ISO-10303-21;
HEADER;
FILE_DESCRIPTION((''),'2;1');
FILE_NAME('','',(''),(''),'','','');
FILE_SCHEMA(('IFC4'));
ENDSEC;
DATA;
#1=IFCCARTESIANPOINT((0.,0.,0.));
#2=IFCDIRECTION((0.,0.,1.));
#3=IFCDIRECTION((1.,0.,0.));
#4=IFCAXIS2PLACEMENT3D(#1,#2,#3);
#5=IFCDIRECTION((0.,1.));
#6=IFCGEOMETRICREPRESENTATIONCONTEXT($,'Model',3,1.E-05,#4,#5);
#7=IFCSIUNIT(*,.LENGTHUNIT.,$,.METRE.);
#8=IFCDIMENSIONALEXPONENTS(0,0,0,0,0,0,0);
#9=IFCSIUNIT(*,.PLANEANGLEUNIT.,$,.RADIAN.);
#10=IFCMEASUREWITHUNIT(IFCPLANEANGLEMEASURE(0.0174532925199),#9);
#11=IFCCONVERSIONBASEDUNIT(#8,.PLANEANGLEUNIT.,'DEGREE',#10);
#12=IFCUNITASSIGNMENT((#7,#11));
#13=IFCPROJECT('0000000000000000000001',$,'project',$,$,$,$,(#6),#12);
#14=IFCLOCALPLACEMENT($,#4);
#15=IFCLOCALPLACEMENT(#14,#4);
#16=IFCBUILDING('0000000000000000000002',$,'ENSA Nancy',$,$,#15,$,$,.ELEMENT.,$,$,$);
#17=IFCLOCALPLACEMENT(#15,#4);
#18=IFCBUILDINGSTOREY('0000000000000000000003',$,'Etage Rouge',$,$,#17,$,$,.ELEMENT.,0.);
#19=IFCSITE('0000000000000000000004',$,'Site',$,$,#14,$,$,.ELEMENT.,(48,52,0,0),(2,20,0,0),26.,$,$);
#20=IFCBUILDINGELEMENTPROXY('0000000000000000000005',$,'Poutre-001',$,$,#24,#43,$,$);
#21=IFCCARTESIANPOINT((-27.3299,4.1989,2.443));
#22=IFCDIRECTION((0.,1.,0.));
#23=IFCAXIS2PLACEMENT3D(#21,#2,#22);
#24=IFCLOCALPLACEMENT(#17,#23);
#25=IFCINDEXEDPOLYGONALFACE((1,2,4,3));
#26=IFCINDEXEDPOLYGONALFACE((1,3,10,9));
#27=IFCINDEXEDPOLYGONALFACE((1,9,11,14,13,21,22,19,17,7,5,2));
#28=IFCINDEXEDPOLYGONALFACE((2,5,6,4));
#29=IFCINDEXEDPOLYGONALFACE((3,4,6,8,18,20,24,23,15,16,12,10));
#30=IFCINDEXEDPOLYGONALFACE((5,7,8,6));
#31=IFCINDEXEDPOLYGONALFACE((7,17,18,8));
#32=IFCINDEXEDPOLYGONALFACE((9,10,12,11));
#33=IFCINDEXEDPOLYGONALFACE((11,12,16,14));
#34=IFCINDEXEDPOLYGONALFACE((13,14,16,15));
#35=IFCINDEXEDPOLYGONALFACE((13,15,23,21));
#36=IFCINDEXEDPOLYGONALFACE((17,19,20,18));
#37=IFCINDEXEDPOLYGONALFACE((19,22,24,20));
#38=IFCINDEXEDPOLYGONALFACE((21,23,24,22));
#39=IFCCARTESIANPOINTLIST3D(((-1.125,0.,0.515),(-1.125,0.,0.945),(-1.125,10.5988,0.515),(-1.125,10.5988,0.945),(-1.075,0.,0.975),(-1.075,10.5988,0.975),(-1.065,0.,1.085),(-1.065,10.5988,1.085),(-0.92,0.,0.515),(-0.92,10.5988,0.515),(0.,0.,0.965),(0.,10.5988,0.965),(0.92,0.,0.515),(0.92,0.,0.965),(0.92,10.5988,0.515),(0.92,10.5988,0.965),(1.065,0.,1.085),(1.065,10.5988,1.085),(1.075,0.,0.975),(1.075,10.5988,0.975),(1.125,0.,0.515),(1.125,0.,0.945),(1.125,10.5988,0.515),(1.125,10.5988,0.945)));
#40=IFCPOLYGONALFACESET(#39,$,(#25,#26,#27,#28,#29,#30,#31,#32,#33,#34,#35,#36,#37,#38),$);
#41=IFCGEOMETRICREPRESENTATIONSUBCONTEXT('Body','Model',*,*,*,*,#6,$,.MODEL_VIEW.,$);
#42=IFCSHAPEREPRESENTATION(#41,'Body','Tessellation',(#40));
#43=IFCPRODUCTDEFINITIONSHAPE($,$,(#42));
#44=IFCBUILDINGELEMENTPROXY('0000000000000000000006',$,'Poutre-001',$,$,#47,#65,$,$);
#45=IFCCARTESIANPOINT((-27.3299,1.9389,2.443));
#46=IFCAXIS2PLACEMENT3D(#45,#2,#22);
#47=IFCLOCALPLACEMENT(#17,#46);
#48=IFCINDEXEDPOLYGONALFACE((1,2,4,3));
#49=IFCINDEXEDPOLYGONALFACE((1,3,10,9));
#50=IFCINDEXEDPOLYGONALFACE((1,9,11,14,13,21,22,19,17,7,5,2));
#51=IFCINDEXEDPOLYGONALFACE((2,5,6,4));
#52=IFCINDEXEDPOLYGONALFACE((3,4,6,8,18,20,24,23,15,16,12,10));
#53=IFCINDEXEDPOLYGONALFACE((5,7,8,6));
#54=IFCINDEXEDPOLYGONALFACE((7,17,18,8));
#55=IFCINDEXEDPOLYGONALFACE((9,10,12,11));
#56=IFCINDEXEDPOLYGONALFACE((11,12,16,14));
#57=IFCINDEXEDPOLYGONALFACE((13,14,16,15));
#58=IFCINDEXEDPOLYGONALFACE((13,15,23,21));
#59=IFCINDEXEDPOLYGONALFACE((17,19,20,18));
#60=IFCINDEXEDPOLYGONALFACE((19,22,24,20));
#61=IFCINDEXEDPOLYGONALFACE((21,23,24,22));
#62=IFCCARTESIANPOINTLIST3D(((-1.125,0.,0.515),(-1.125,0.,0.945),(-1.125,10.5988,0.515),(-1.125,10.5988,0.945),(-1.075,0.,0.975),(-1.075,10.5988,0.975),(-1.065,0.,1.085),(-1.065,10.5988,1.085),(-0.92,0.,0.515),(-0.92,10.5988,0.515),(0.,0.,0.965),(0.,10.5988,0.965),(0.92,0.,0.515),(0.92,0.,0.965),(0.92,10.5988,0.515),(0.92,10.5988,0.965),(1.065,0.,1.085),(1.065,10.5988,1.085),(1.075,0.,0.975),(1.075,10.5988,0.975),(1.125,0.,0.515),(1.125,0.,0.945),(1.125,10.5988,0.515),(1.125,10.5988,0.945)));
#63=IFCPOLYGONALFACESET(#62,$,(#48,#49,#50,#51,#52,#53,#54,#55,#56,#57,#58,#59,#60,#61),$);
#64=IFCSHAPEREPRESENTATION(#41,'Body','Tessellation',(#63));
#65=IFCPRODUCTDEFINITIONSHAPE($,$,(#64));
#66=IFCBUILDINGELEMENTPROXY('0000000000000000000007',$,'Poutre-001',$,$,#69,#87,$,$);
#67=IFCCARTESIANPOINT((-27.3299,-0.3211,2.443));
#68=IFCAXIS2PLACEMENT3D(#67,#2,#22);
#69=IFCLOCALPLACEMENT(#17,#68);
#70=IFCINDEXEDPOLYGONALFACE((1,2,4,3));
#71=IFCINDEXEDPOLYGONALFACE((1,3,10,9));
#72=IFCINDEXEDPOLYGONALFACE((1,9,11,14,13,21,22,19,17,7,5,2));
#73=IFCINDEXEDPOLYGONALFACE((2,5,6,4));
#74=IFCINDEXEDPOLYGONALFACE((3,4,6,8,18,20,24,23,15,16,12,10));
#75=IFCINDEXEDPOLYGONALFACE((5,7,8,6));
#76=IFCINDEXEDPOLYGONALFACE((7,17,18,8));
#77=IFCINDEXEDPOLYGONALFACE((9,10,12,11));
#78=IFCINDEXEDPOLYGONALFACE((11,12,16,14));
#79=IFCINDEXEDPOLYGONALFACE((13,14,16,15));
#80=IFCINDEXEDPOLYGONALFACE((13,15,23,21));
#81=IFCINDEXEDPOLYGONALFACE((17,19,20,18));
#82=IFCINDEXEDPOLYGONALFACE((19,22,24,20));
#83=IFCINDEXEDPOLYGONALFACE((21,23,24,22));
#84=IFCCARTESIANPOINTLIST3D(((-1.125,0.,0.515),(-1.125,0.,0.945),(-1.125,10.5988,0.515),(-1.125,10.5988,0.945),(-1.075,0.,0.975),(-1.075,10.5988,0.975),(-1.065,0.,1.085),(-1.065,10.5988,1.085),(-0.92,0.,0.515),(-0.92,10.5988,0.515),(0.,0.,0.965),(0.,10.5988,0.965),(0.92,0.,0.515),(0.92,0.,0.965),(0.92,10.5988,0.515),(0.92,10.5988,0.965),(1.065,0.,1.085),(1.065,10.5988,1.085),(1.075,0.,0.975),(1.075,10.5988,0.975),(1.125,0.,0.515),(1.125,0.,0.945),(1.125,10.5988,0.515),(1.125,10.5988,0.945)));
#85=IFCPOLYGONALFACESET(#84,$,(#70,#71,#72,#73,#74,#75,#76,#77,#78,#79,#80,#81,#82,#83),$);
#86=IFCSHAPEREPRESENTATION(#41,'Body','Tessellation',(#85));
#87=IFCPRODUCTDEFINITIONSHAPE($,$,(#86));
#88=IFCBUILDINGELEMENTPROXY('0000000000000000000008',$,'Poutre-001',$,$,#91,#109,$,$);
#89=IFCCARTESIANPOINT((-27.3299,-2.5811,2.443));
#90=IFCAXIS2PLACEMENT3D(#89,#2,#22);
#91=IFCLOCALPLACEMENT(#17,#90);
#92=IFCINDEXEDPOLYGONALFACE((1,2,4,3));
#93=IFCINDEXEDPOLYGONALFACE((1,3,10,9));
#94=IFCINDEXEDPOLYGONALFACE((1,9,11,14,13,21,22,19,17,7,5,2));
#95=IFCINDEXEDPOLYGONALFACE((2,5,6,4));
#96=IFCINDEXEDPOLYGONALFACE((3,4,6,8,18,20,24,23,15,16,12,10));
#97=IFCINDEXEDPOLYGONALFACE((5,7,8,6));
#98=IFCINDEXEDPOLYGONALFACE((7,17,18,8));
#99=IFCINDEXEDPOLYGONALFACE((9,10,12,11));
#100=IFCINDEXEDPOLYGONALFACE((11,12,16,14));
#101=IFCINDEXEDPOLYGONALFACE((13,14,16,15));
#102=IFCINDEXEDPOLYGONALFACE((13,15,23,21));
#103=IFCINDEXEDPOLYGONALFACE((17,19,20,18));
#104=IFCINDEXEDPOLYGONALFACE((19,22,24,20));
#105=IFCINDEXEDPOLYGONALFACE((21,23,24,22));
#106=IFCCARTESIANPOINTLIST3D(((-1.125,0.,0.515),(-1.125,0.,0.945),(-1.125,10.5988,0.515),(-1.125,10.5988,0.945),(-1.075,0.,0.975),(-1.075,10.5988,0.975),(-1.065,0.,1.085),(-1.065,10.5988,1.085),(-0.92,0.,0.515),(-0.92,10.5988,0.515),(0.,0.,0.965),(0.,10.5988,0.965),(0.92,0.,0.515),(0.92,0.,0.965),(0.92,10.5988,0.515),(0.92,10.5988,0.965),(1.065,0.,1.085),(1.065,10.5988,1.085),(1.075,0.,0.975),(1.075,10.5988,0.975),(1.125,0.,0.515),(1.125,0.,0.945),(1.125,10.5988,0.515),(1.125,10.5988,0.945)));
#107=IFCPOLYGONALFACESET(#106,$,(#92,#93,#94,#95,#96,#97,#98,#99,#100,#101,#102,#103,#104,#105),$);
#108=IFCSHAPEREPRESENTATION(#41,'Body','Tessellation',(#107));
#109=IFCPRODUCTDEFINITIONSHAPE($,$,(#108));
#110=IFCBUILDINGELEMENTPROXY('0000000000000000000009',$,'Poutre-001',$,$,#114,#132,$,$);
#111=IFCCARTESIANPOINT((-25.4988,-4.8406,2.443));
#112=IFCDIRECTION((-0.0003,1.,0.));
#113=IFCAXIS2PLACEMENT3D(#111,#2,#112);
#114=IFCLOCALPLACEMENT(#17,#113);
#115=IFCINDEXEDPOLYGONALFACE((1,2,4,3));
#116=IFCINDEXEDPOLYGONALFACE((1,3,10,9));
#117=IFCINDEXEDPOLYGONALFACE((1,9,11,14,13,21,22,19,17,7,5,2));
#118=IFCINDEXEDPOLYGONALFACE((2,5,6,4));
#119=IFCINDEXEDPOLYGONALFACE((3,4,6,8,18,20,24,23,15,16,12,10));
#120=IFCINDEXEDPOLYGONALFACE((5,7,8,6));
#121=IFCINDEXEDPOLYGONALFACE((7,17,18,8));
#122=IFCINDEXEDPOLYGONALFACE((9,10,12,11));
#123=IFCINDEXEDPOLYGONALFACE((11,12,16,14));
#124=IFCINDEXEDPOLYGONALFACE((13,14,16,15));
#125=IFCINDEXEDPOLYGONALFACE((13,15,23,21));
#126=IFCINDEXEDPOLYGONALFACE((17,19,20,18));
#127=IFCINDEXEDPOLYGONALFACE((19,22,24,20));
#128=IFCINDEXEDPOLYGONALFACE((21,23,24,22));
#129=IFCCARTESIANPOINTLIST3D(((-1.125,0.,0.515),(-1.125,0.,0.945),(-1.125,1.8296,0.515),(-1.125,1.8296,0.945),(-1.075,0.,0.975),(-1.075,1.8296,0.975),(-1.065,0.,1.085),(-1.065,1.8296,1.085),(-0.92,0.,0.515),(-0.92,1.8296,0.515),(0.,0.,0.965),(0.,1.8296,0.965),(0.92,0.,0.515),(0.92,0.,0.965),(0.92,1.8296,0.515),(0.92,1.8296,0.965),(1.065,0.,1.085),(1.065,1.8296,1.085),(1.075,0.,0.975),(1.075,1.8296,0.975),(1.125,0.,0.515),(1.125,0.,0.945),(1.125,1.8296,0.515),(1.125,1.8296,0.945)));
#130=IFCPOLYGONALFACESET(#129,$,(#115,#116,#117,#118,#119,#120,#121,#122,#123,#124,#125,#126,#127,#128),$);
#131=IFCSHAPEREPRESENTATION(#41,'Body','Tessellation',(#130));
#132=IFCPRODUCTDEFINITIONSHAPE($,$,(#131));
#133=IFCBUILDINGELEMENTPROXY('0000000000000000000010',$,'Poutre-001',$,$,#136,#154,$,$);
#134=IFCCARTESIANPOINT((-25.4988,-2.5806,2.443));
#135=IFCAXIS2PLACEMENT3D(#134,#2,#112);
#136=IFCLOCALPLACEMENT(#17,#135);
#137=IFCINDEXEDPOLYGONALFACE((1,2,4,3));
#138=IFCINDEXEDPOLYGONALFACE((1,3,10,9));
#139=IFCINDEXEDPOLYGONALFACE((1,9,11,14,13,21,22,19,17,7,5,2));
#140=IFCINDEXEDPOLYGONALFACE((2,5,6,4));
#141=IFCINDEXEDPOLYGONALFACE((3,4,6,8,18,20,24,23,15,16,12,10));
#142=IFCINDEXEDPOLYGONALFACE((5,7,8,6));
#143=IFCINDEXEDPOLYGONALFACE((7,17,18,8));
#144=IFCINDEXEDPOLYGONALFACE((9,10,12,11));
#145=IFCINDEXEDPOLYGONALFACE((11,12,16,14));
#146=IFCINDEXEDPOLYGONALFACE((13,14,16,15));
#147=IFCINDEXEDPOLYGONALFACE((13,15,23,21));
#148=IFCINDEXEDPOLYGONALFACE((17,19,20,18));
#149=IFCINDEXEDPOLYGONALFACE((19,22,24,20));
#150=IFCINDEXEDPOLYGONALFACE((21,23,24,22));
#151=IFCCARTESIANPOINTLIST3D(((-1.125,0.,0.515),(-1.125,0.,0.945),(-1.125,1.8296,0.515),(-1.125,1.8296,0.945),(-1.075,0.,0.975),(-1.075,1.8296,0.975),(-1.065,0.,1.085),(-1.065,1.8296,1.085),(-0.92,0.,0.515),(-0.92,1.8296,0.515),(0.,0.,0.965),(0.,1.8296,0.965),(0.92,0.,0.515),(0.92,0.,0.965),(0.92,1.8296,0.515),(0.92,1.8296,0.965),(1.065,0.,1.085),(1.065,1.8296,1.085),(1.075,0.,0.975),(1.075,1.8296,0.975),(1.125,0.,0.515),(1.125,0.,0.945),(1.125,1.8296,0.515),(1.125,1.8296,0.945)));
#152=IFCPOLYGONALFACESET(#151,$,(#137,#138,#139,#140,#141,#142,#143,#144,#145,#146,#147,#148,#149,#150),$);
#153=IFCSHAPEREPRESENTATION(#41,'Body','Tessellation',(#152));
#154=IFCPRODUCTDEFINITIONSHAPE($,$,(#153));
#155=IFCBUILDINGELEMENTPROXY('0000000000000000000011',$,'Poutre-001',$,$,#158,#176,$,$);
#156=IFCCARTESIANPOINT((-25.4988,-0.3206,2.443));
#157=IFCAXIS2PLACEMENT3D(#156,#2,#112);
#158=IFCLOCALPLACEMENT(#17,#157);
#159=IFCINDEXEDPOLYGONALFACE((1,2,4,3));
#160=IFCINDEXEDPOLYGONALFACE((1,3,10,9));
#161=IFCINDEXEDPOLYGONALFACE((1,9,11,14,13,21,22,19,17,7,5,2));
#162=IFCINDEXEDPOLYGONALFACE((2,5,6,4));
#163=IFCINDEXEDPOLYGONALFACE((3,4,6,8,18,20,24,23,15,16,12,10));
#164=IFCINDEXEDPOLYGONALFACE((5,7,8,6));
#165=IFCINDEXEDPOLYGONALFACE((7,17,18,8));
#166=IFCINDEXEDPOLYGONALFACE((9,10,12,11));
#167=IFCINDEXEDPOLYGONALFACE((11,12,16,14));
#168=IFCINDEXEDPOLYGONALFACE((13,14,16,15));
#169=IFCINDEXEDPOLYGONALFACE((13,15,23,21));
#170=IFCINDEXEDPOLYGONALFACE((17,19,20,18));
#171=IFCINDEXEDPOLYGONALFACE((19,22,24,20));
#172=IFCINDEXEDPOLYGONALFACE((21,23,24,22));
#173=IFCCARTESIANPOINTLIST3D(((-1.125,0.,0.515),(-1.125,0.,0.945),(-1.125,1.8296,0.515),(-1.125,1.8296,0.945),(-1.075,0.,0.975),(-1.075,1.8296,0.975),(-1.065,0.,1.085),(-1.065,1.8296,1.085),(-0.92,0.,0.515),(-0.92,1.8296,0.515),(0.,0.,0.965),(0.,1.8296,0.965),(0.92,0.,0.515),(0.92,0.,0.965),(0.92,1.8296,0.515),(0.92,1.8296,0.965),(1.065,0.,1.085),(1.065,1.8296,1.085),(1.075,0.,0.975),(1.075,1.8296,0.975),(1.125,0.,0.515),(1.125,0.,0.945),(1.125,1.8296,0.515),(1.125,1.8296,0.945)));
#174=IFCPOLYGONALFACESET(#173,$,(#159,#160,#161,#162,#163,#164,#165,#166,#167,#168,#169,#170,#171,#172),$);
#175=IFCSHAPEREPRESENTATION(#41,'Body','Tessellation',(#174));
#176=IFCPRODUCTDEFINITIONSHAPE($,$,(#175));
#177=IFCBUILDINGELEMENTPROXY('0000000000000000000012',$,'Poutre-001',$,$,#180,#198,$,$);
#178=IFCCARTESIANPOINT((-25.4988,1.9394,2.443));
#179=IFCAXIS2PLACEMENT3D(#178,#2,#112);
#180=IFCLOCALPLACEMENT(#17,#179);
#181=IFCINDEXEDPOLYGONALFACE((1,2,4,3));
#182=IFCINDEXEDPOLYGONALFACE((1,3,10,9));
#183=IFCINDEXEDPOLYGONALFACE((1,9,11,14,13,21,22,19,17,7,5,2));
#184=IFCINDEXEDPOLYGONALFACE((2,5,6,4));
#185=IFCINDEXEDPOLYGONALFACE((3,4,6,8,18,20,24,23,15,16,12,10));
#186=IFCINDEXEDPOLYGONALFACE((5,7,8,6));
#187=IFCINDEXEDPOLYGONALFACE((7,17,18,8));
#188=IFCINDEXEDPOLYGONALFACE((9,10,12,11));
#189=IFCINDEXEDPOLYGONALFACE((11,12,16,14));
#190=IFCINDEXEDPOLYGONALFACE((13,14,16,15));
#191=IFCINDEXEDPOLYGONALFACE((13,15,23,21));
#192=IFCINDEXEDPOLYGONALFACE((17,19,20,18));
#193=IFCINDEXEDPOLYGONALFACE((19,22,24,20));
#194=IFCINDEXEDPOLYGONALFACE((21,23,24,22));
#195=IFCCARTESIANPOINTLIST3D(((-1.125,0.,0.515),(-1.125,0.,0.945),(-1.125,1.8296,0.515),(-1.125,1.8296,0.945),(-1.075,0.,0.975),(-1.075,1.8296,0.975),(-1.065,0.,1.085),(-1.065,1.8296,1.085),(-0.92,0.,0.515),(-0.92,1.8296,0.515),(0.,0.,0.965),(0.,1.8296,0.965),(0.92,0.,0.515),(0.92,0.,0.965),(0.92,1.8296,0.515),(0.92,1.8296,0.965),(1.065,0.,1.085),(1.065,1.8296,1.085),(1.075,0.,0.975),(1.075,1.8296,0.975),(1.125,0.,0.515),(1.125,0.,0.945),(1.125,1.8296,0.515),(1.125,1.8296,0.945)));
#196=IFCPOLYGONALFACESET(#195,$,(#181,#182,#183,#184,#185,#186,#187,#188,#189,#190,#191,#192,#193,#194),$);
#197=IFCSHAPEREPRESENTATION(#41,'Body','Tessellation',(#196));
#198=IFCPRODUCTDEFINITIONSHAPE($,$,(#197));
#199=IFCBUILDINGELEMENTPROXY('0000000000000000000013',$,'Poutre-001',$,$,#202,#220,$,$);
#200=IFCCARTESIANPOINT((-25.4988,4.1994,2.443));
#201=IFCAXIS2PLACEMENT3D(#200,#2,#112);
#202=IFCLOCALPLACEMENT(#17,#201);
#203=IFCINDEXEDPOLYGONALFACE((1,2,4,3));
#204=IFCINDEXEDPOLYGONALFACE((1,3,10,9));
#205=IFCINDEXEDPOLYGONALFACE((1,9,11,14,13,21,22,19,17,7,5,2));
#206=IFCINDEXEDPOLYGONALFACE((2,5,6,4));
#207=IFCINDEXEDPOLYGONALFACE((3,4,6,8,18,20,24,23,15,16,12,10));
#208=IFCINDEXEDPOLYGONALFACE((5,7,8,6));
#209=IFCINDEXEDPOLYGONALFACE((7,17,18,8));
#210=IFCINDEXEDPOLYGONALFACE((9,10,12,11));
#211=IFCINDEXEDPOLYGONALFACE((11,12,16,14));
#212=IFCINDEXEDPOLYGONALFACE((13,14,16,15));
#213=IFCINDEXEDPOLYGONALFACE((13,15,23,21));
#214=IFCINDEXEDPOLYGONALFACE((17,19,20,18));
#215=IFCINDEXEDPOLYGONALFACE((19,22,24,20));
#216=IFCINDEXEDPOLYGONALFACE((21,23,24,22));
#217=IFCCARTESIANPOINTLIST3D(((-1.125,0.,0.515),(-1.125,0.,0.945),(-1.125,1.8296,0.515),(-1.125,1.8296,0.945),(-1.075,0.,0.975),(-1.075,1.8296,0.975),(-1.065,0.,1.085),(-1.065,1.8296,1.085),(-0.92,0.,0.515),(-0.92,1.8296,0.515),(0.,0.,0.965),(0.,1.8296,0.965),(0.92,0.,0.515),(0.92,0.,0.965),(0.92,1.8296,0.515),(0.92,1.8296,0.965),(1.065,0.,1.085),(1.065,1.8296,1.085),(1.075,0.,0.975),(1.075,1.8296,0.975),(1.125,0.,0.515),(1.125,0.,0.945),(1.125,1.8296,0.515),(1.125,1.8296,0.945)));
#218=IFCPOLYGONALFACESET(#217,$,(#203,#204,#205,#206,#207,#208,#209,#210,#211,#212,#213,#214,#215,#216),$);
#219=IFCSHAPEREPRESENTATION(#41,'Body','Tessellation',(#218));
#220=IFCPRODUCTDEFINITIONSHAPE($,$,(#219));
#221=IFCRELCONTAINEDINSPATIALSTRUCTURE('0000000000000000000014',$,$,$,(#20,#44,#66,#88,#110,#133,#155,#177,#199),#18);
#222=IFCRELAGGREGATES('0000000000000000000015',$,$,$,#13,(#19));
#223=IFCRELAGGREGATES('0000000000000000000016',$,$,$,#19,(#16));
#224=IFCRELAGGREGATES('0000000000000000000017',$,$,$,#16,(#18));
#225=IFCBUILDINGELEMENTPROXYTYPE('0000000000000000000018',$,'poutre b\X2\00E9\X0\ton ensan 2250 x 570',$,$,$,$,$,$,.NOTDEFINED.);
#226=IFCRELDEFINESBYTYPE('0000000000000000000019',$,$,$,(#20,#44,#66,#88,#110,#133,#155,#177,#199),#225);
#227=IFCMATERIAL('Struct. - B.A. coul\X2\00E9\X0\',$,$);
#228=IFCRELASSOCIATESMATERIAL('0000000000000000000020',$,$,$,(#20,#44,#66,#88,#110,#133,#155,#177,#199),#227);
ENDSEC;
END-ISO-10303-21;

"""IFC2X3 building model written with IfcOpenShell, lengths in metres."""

from ifc_helpers import new_model, entity, si_unit, converted_unit, direction, frame, origin_with_axes, place, context, subcontext, project, spatial, polyline, outline, extrude, material, type_object, element, save


model = new_model("IFC2X3")

# Units and contexts
model_context = context("Model", 3, precision=1e-05, world=origin_with_axes(), true_north=direction((0.0, 1.0)))
body_context = subcontext(model_context, "Body", "Model", "MODEL_VIEW")
ifc_project = project(units=[si_unit("LENGTHUNIT", "METRE"), converted_unit("PLANEANGLEUNIT", "DEGREE", entity("IfcPlaneAngleMeasure", 0.0174532925199), si_unit("PLANEANGLEUNIT", "RADIAN"), dimensions=[0, 0, 0, 0, 0, 0, 0])], contexts=[model_context])

# Site, building, storey
site_placement = place(None, origin_with_axes())
site = spatial("IfcSite", under=ifc_project, at=site_placement, Name="Site", CompositionType="ELEMENT", RefLatitude=(48, 52, 0, 0), RefLongitude=(2, 20, 0, 0), RefElevation=26.0)
building_placement = place(site_placement, origin_with_axes())
building = spatial("IfcBuilding", under=site, at=building_placement, Name="ENSA Nancy", CompositionType="ELEMENT")
storey_placement = place(building_placement, origin_with_axes())
storey = spatial("IfcBuildingStorey", under=building, at=storey_placement, Name="Etage Rouge", CompositionType="ELEMENT", Elevation=0.0)

# Building element proxies
ifc_material_1 = material(Name="Struct. - B.A. coulé")
building_element_proxy_type_1 = type_object("IfcBuildingElementProxyType", Name="poutre béton ensan 2250 x 570", PredefinedType="NOTDEFINED")
proxy_1_placement = place(storey_placement, frame((-27.3299, 4.1989, 2.443), z_axis=(0.0, 0.0, 1.0), x_axis=(0.0, 1.0, 0.0)))
element("IfcBuildingElementProxy", 1, at=proxy_1_placement, inside=storey, type_object=building_element_proxy_type_1, material=ifc_material_1, Name="Poutre-001", context=body_context, shape_type="SweptSolid", body=[
    extrude(outline(polyline([(-1.065, 1.085), (-1.075, 0.975), (-1.125, 0.945), (-1.125, 0.515), (-0.92, 0.515), (0.0, 0.965), (0.92, 0.965), (0.92, 0.515), (1.125, 0.515), (1.125, 0.945), (1.075, 0.975), (1.065, 1.085), (-1.065, 1.085)])), frame((0.0, 10.5988, 0.0), z_axis=(0.0, -1.0, 0.0), x_axis=(1.0, 0.0, 0.0)), (0.0, 0.0, 1.0), 10.5988),
])
for number, where, z_axis, x_axis, name in (
    (2, (-27.3299, 1.9389, 2.443), (0.0, 0.0, 1.0), (0.0, 1.0, 0.0), "Poutre-001"),
    (3, (-27.3299, -0.3211, 2.443), (0.0, 0.0, 1.0), (0.0, 1.0, 0.0), "Poutre-001"),
    (4, (-27.3299, -2.5811, 2.443), (0.0, 0.0, 1.0), (0.0, 1.0, 0.0), "Poutre-001"),
):
    element("IfcBuildingElementProxy", number, at=place(storey_placement, frame(where, z_axis=z_axis, x_axis=x_axis)), inside=storey, type_object=building_element_proxy_type_1, material=ifc_material_1, Name=name, context=body_context, shape_type="SweptSolid", body=[
        extrude(outline(polyline([(-1.065, 1.085), (-1.075, 0.975), (-1.125, 0.945), (-1.125, 0.515), (-0.92, 0.515), (0.0, 0.965), (0.92, 0.965), (0.92, 0.515), (1.125, 0.515), (1.125, 0.945), (1.075, 0.975), (1.065, 1.085), (-1.065, 1.085)])), frame((0.0, 10.5988, 0.0), z_axis=(0.0, -1.0, 0.0), x_axis=(1.0, 0.0, 0.0)), (0.0, 0.0, 1.0), 10.5988),
    ])
for number, where, z_axis, x_axis, name in (
    (5, (-25.4988, -4.8406, 2.443), (0.0, 0.0, 1.0), (-0.0003, 1.0, 0.0), "Poutre-001"),
    (6, (-25.4988, -2.5806, 2.443), (0.0, 0.0, 1.0), (-0.0003, 1.0, 0.0), "Poutre-001"),
    (7, (-25.4988, -0.3206, 2.443), (0.0, 0.0, 1.0), (-0.0003, 1.0, 0.0), "Poutre-001"),
    (8, (-25.4988, 1.9394, 2.443), (0.0, 0.0, 1.0), (-0.0003, 1.0, 0.0), "Poutre-001"),
    (9, (-25.4988, 4.1994, 2.443), (0.0, 0.0, 1.0), (-0.0003, 1.0, 0.0), "Poutre-001"),
):
    element("IfcBuildingElementProxy", number, at=place(storey_placement, frame(where, z_axis=z_axis, x_axis=x_axis)), inside=storey, type_object=building_element_proxy_type_1, material=ifc_material_1, Name=name, context=body_context, shape_type="SweptSolid", body=[
        extrude(outline(polyline([(-1.065, 1.085), (-1.075, 0.975), (-1.125, 0.945), (-1.125, 0.515), (-0.92, 0.515), (0.0, 0.965), (0.92, 0.965), (0.92, 0.515), (1.125, 0.515), (1.125, 0.945), (1.075, 0.975), (1.065, 1.085), (-1.065, 1.085)])), frame((0.0, 1.8296, 0.0), z_axis=(0.0, -1.0, 0.0), x_axis=(1.0, 0.0, 0.0)), (0.0, 0.0, 1.0), 1.8296),
    ])

save(model, "model.ifc")
